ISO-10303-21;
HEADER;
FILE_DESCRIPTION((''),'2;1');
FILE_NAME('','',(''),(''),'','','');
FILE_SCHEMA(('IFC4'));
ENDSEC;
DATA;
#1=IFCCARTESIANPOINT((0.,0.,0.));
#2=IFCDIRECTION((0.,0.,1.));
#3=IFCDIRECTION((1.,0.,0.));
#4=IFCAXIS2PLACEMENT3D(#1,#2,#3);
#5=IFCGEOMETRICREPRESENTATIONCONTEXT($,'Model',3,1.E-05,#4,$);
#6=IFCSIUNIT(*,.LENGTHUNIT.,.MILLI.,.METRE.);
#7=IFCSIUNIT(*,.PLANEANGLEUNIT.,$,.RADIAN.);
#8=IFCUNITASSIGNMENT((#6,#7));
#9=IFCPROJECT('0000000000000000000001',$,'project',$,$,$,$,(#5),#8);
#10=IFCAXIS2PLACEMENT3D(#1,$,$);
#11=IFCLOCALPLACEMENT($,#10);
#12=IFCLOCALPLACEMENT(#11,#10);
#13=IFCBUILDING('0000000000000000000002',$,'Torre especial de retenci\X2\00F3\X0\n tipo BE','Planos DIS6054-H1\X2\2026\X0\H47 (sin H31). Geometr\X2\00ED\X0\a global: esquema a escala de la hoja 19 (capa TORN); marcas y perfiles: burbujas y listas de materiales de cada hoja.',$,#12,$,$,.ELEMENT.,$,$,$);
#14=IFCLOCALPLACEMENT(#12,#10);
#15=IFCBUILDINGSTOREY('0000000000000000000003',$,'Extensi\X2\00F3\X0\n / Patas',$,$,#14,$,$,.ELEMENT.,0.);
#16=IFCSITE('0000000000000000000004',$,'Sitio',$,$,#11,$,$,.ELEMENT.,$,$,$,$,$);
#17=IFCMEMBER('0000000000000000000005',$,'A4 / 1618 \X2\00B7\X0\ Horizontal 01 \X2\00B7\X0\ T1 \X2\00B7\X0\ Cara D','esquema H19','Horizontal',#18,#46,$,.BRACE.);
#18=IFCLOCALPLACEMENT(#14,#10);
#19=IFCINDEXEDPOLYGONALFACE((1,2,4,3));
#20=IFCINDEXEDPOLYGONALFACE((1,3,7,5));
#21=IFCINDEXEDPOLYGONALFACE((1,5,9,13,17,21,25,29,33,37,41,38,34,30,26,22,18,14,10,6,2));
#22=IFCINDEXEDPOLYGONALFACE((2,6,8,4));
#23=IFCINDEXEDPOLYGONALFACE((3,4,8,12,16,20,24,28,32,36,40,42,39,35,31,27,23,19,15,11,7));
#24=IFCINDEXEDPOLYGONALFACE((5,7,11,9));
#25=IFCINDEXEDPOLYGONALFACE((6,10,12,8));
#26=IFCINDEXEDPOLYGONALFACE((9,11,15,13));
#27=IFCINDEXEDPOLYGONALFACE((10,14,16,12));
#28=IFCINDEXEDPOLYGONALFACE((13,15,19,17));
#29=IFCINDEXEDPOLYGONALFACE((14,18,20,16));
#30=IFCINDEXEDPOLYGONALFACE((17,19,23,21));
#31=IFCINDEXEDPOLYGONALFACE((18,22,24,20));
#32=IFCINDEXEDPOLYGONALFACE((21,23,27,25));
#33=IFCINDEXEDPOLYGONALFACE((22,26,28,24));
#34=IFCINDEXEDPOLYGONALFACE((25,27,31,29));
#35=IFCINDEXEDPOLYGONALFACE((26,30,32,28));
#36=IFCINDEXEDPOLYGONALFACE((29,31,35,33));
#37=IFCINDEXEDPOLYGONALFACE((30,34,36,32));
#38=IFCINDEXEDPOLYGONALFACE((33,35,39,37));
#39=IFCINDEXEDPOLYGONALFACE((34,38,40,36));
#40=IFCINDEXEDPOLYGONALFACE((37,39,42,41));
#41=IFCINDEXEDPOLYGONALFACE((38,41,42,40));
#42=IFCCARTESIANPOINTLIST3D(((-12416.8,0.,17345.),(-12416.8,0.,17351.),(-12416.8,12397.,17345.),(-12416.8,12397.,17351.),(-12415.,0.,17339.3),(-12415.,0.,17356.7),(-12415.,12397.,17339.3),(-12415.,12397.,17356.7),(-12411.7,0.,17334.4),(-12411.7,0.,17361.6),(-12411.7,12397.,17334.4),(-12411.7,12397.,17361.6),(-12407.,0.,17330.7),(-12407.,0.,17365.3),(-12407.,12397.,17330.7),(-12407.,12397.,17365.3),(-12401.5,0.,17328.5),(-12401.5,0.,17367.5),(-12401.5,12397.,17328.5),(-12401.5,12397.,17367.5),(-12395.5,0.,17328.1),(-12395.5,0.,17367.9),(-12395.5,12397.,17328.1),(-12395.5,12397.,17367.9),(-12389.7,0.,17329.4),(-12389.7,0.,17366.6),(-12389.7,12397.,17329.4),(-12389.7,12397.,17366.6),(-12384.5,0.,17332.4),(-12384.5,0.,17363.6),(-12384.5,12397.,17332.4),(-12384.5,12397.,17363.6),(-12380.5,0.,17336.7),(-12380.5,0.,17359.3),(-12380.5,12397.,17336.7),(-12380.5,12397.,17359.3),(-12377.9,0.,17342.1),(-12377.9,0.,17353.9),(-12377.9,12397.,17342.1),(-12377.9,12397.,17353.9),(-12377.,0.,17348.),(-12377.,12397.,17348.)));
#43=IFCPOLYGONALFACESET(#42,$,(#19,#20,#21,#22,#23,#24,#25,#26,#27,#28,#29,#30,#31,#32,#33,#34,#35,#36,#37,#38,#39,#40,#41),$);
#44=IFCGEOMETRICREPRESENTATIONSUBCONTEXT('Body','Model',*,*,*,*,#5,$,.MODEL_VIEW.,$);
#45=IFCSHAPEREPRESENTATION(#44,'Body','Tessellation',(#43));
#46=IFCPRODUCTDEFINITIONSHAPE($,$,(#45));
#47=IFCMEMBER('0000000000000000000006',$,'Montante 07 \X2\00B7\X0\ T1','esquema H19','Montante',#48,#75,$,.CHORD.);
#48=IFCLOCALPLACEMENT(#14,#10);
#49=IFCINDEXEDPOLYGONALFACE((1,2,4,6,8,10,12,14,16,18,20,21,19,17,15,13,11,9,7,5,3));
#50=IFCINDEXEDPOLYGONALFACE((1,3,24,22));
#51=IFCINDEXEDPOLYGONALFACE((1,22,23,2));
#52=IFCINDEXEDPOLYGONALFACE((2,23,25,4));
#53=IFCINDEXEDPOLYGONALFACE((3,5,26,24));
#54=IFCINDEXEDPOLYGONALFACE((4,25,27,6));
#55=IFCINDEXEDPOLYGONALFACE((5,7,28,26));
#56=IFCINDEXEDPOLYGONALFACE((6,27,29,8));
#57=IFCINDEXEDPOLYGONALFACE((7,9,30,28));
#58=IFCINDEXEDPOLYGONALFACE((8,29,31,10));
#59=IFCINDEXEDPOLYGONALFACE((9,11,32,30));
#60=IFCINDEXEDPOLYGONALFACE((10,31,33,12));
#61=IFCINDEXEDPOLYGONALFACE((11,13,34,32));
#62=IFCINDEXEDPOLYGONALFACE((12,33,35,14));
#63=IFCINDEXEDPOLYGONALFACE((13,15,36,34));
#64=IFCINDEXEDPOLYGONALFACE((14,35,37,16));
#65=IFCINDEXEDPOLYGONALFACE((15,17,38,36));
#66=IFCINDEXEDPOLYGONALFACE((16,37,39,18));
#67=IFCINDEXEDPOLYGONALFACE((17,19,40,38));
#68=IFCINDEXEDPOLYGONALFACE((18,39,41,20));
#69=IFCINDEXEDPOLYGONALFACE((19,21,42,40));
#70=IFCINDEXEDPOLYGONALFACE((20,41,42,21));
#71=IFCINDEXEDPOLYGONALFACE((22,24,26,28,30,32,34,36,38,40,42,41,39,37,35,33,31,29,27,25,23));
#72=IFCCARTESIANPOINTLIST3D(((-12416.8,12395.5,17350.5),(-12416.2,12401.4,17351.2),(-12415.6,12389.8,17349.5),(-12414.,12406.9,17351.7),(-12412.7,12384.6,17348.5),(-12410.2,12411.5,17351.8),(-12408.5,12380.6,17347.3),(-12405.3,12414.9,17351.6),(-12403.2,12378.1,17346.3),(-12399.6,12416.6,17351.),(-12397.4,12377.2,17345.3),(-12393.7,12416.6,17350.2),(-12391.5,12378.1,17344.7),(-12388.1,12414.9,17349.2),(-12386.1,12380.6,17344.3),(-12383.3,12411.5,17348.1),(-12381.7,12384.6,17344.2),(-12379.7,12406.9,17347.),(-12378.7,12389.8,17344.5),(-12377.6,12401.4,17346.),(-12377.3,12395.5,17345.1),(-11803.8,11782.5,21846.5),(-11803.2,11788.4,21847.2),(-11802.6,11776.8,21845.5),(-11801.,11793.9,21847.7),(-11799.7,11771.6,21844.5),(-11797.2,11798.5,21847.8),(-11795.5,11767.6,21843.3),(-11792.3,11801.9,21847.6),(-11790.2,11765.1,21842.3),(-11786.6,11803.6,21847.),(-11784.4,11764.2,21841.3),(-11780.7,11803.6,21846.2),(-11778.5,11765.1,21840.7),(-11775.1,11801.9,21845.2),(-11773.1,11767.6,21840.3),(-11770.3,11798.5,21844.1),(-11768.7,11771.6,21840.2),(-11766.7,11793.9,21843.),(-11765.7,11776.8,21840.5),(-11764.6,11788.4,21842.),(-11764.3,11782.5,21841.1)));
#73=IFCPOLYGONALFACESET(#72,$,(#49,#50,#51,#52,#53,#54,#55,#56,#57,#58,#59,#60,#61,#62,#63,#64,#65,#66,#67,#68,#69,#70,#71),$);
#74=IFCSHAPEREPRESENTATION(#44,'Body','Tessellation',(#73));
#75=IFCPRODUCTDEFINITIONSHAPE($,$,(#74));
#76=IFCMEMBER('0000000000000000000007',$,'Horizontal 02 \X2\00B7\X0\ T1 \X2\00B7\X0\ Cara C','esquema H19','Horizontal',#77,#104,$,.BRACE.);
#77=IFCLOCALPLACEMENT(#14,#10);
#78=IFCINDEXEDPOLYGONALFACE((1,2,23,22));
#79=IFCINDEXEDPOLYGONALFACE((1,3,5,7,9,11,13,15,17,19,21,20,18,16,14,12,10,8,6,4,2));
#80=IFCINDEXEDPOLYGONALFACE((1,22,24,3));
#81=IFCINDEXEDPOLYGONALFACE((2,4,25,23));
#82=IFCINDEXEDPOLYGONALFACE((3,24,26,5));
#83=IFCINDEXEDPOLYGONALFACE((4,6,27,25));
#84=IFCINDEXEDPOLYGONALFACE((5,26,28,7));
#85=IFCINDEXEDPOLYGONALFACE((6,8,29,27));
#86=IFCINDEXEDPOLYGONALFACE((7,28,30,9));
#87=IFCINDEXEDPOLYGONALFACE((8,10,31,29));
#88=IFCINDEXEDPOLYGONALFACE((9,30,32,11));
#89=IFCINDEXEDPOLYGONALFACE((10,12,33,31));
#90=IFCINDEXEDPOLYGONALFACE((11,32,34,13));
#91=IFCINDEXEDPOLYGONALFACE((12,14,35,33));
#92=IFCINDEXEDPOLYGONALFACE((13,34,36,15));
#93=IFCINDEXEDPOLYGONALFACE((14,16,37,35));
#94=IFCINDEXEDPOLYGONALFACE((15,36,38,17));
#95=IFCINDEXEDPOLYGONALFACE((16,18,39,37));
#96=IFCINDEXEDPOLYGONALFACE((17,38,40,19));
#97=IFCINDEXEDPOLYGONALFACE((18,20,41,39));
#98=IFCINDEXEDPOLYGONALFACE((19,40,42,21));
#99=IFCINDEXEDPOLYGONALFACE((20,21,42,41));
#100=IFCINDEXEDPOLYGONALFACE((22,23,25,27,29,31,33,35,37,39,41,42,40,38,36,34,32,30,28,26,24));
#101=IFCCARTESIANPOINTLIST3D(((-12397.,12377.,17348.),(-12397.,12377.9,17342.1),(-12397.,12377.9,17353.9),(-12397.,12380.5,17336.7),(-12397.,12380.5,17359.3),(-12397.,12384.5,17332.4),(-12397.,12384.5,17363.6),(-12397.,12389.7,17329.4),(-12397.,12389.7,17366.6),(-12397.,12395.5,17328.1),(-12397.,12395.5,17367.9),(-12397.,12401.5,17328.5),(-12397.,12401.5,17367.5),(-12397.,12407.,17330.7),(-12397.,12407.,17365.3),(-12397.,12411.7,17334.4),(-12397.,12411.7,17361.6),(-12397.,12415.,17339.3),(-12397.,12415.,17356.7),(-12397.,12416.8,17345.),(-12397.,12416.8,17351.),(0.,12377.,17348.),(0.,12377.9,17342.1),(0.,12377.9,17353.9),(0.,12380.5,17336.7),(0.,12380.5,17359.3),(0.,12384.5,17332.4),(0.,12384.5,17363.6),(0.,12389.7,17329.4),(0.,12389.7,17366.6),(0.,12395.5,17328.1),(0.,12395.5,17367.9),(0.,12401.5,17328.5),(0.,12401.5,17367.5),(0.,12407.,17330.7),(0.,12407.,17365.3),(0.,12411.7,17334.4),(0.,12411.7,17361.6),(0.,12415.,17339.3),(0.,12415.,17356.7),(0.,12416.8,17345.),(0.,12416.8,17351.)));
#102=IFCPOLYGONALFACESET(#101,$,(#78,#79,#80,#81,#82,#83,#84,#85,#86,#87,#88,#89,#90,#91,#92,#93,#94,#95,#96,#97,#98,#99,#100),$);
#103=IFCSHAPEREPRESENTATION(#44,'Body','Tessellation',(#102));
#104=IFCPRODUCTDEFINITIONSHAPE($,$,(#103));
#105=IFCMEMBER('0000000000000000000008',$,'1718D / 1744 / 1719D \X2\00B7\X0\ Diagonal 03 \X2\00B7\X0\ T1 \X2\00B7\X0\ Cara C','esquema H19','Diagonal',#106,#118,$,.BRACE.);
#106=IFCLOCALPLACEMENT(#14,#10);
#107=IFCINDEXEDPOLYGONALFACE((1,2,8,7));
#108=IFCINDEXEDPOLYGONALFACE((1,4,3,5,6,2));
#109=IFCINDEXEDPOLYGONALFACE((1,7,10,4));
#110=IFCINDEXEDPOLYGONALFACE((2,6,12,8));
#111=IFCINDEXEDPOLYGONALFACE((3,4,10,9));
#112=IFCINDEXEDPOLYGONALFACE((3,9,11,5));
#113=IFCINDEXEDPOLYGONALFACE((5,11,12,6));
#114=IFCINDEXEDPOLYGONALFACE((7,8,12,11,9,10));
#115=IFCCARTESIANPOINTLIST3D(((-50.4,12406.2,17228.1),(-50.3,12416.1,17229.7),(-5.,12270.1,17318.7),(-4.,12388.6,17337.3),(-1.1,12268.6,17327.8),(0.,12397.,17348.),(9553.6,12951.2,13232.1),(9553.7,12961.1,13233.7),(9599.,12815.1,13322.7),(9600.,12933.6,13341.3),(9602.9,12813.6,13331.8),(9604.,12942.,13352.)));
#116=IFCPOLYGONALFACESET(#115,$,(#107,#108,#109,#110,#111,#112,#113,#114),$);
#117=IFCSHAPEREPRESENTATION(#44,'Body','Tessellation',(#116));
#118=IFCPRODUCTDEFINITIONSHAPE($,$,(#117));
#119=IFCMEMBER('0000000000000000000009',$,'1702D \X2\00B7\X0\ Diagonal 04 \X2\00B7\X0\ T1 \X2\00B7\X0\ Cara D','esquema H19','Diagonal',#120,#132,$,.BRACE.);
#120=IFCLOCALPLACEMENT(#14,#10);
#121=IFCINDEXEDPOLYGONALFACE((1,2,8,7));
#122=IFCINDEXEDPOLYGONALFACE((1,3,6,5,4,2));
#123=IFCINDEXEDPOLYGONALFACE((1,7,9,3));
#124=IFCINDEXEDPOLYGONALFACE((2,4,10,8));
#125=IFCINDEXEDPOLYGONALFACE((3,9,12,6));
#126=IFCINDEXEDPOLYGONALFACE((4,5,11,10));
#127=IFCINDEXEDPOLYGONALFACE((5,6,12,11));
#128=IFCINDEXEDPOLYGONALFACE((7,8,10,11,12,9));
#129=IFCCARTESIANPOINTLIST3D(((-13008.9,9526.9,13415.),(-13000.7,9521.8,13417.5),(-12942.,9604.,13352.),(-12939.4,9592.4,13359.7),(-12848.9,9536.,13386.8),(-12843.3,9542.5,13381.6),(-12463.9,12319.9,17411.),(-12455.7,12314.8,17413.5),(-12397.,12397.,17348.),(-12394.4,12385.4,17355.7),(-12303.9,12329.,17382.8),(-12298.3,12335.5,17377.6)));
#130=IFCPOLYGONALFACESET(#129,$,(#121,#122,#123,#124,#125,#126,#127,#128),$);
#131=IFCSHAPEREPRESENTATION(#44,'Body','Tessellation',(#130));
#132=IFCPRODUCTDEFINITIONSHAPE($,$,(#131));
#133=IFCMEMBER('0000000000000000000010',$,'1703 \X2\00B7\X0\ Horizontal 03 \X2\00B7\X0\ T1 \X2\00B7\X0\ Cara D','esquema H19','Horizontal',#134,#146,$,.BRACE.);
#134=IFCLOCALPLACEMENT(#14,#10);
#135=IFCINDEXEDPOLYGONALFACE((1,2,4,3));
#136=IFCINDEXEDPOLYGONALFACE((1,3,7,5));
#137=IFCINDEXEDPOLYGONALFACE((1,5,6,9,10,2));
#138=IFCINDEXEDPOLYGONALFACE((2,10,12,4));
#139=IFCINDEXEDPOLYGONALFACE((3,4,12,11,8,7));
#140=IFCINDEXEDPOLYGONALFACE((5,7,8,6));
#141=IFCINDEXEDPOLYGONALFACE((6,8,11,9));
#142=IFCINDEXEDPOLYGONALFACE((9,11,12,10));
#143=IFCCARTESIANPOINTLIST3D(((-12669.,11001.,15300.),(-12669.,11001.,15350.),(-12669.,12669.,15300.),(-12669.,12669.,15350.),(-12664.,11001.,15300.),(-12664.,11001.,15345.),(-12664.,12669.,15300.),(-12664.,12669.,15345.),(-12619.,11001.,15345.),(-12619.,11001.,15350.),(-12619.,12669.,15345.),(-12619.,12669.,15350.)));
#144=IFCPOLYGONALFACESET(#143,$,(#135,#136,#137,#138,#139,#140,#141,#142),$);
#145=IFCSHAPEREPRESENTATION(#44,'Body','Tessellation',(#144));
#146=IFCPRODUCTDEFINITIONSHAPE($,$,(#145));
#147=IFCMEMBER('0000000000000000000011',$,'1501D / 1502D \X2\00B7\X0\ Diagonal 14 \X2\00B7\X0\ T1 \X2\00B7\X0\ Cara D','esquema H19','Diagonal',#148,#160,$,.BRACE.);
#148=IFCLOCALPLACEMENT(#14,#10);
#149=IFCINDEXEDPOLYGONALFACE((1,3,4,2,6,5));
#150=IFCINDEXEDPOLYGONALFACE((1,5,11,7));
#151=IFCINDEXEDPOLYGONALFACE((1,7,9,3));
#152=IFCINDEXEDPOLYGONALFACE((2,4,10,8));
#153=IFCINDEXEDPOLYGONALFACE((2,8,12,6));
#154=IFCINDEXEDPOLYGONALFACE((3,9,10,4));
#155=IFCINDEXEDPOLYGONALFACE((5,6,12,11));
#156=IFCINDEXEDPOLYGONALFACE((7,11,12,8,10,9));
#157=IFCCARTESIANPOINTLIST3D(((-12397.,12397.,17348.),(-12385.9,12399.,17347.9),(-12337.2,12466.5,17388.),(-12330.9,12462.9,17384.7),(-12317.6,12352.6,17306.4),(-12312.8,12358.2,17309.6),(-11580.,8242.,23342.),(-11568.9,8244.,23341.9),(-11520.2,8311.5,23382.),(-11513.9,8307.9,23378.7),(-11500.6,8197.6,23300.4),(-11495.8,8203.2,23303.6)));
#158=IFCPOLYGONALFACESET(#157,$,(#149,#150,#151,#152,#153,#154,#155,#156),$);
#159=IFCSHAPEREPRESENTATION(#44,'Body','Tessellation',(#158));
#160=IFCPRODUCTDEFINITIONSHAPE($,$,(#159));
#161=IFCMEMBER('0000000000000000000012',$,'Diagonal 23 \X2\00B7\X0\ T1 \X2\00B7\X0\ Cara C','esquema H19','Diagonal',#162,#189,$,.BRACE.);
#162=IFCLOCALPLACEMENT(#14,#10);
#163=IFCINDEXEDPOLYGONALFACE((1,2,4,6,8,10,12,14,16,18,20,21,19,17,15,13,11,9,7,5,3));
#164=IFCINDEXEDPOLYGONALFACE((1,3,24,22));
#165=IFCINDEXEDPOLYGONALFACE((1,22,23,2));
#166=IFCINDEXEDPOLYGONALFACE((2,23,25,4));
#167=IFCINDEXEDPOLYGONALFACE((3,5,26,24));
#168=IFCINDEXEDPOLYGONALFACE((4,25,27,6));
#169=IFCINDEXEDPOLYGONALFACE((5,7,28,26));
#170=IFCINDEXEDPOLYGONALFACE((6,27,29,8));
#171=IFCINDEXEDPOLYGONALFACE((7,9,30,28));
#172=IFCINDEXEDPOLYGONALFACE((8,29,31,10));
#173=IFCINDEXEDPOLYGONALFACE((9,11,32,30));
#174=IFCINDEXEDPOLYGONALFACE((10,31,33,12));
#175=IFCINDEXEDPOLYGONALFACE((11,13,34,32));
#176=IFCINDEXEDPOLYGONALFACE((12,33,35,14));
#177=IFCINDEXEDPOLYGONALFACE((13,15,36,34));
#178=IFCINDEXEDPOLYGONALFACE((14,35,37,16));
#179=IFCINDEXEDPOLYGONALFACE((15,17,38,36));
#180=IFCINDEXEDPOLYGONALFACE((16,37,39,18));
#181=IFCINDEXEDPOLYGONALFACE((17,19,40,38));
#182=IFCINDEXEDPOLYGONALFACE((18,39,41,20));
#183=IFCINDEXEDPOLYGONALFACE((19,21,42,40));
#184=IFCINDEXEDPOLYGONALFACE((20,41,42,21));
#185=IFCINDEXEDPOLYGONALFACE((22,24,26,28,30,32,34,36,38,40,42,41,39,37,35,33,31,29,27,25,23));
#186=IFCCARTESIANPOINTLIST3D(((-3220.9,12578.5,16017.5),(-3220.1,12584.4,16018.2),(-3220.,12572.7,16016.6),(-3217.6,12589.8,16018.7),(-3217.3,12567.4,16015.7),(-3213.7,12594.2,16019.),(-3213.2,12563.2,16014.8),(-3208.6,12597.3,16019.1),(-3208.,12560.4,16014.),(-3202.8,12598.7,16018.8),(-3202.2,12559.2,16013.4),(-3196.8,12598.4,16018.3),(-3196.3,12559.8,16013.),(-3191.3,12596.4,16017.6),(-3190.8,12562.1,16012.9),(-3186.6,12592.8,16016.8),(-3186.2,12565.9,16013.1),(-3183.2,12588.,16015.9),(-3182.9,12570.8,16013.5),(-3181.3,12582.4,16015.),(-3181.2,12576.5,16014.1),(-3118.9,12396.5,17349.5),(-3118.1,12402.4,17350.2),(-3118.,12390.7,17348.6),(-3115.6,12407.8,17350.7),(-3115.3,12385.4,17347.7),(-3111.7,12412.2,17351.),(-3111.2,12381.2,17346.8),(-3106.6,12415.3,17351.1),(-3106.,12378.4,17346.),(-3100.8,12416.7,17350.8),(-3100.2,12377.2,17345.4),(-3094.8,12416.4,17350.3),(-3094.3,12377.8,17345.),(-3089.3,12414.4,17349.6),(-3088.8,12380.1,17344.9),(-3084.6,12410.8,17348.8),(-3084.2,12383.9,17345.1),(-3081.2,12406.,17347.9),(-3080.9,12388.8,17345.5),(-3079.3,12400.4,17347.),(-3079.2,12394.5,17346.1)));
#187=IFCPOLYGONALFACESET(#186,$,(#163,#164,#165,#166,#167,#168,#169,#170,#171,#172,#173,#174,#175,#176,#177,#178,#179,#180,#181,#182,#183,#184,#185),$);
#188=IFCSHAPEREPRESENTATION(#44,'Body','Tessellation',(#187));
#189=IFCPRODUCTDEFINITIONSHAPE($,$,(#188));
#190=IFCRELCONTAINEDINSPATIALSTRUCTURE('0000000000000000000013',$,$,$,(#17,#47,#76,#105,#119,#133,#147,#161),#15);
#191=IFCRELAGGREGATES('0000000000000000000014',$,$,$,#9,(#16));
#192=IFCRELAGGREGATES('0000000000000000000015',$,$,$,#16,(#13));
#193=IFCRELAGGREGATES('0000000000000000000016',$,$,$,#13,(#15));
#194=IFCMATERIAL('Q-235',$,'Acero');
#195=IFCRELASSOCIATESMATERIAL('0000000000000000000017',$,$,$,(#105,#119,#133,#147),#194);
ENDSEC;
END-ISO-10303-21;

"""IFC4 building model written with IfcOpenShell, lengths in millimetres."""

from ifc_helpers import new_model, si_unit, frame, frame_2d, origin, origin_with_axes, place, context, subcontext, project, spatial, circle, l_section, extrude, material, element, save


model = new_model("IFC4")

# Units and contexts
model_context = context("Model", 3, precision=1e-05, world=origin_with_axes())
body_context = subcontext(model_context, "Body", "Model", "MODEL_VIEW")
ifc_project = project(units=[si_unit("LENGTHUNIT", "METRE", prefix="MILLI"), si_unit("PLANEANGLEUNIT", "RADIAN")], contexts=[model_context])

# Site, building, storey
site_placement = place(None, origin())
site = spatial("IfcSite", under=ifc_project, at=site_placement, Name="Sitio", CompositionType="ELEMENT")
building_placement = place(site_placement, origin())
building = spatial("IfcBuilding", under=site, at=building_placement, Name="Torre especial de retención tipo BE", Description="Planos DIS6054-H1…H47 (sin H31). Geometría global: esquema a escala de la hoja 19 (capa TORN); marcas y perfiles: burbujas y listas de materiales de cada hoja.", CompositionType="ELEMENT")
storey_placement = place(building_placement, origin())
storey = spatial("IfcBuildingStorey", under=building, at=storey_placement, Name="Extensión / Patas", CompositionType="ELEMENT", Elevation=0.0)

# Members
member_1_placement = place(storey_placement, frame((-12397.0, 12397.0, 17348.0), z_axis=(0.0, -1.0, 0.0), x_axis=(1.0, 0.0, 0.0)))
element("IfcMember", 1, at=member_1_placement, inside=storey, Name="A4 / 1618 · Horizontal 01 · T1 · Cara D", Description="esquema H19", ObjectType="Horizontal", PredefinedType="BRACE", context=body_context, shape_type="SweptSolid", body=[
    extrude(circle(Radius=20.0), None, (0.0, 0.0, 1.0), 12397.0),
])
member_2_placement = place(storey_placement, frame((-12397.0, 12397.0, 17348.0), z_axis=(0.133877, -0.133877, 0.981913), x_axis=(-0.018086, -0.990998, -0.13265)))
element("IfcMember", 2, at=member_2_placement, inside=storey, Name="Montante 07 · T1", Description="esquema H19", ObjectType="Montante", PredefinedType="CHORD", context=body_context, shape_type="SweptSolid", body=[
    extrude(circle(Radius=20.0), None, (0.0, 0.0, 1.0), 4578.8),
])
member_3_placement = place(storey_placement, frame((-12397.0, 12397.0, 17348.0), z_axis=(1.0, 0.0, 0.0), x_axis=(0.0, -1.0, 0.0)))
element("IfcMember", 3, at=member_3_placement, inside=storey, Name="Horizontal 02 · T1 · Cara C", Description="esquema H19", ObjectType="Horizontal", PredefinedType="BRACE", context=body_context, shape_type="SweptSolid", body=[
    extrude(circle(Radius=20.0), None, (0.0, 0.0, 1.0), 12397.0),
])
ifc_material = material(Name="Q-235", Category="Acero")
member_4_placement = place(storey_placement, frame((0.0, 12397.0, 17348.0), z_axis=(0.922006, 0.052321, -0.383625), x_axis=(-0.008654, -0.987795, -0.155521)))
element("IfcMember", 4, at=member_4_placement, inside=storey, material=ifc_material, Name="1718D / 1744 / 1719D · Diagonal 03 · T1 · Cara C", Description="esquema H19", ObjectType="Diagonal", PredefinedType="BRACE", context=body_context, shape_type="SweptSolid", body=[
    extrude(l_section(Depth=130.0, Width=130.0, Thickness=10.0, at=frame_2d((65.0, 65.0))), None, (0.0, 0.0, 1.0), 10416.4),
])
member_5_placement = place(storey_placement, frame((-12397.0, 12397.0, 17348.0), z_axis=(-0.111095, -0.569338, -0.814563), x_axis=(0.822429, -0.512805, 0.246256)))
element("IfcMember", 5, at=member_5_placement, inside=storey, material=ifc_material, Name="1702D · Diagonal 04 · T1 · Cara D", Description="esquema H19", ObjectType="Diagonal", PredefinedType="BRACE", context=body_context, shape_type="SweptSolid", body=[
    extrude(l_section(Depth=120.0, Width=120.0, Thickness=10.0, at=frame_2d((60.0, 60.0))), None, (0.0, 0.0, 1.0), 4905.7),
])
member_6_placement = place(storey_placement, frame((-12669.0, 11001.0, 15350.0), z_axis=(0.0, 1.0, 0.0), x_axis=(1.0, 0.0, 0.0)))
element("IfcMember", 6, at=member_6_placement, inside=storey, material=ifc_material, Name="1703 · Horizontal 03 · T1 · Cara D", Description="esquema H19", ObjectType="Horizontal", PredefinedType="BRACE", context=body_context, shape_type="SweptSolid", body=[
    extrude(l_section(Depth=50.0, Width=50.0, Thickness=5.0, at=frame_2d((25.0, 25.0))), None, (0.0, 0.0, 1.0), 1668.0),
])
member_7_placement = place(storey_placement, frame((-12397.0, 12397.0, 17348.0), z_axis=(0.111324, -0.566161, 0.816743), x_axis=(0.793791, -0.443812, -0.415844)))
element("IfcMember", 7, at=member_7_placement, inside=storey, material=ifc_material, Name="1501D / 1502D · Diagonal 14 · T1 · Cara D", Description="esquema H19", ObjectType="Diagonal", PredefinedType="BRACE", context=body_context, shape_type="SweptSolid", body=[
    extrude(l_section(Depth=100.0, Width=100.0, Thickness=8.0, at=frame_2d((50.0, 50.0))), None, (0.0, 0.0, 1.0), 7338.9),
])
member_8_placement = place(storey_placement, frame((-3099.0, 12397.0, 17348.0), z_axis=(-0.075654, 0.134991, -0.987954), x_axis=(0.235927, -0.960238, -0.14927)))
element("IfcMember", 8, at=member_8_placement, inside=storey, Name="Diagonal 23 · T1 · Cara C", Description="esquema H19", ObjectType="Diagonal", PredefinedType="BRACE", context=body_context, shape_type="SweptSolid", body=[
    extrude(circle(Radius=20.0), None, (0.0, 0.0, 1.0), 1348.2),
])

save(model, "model.ifc")
